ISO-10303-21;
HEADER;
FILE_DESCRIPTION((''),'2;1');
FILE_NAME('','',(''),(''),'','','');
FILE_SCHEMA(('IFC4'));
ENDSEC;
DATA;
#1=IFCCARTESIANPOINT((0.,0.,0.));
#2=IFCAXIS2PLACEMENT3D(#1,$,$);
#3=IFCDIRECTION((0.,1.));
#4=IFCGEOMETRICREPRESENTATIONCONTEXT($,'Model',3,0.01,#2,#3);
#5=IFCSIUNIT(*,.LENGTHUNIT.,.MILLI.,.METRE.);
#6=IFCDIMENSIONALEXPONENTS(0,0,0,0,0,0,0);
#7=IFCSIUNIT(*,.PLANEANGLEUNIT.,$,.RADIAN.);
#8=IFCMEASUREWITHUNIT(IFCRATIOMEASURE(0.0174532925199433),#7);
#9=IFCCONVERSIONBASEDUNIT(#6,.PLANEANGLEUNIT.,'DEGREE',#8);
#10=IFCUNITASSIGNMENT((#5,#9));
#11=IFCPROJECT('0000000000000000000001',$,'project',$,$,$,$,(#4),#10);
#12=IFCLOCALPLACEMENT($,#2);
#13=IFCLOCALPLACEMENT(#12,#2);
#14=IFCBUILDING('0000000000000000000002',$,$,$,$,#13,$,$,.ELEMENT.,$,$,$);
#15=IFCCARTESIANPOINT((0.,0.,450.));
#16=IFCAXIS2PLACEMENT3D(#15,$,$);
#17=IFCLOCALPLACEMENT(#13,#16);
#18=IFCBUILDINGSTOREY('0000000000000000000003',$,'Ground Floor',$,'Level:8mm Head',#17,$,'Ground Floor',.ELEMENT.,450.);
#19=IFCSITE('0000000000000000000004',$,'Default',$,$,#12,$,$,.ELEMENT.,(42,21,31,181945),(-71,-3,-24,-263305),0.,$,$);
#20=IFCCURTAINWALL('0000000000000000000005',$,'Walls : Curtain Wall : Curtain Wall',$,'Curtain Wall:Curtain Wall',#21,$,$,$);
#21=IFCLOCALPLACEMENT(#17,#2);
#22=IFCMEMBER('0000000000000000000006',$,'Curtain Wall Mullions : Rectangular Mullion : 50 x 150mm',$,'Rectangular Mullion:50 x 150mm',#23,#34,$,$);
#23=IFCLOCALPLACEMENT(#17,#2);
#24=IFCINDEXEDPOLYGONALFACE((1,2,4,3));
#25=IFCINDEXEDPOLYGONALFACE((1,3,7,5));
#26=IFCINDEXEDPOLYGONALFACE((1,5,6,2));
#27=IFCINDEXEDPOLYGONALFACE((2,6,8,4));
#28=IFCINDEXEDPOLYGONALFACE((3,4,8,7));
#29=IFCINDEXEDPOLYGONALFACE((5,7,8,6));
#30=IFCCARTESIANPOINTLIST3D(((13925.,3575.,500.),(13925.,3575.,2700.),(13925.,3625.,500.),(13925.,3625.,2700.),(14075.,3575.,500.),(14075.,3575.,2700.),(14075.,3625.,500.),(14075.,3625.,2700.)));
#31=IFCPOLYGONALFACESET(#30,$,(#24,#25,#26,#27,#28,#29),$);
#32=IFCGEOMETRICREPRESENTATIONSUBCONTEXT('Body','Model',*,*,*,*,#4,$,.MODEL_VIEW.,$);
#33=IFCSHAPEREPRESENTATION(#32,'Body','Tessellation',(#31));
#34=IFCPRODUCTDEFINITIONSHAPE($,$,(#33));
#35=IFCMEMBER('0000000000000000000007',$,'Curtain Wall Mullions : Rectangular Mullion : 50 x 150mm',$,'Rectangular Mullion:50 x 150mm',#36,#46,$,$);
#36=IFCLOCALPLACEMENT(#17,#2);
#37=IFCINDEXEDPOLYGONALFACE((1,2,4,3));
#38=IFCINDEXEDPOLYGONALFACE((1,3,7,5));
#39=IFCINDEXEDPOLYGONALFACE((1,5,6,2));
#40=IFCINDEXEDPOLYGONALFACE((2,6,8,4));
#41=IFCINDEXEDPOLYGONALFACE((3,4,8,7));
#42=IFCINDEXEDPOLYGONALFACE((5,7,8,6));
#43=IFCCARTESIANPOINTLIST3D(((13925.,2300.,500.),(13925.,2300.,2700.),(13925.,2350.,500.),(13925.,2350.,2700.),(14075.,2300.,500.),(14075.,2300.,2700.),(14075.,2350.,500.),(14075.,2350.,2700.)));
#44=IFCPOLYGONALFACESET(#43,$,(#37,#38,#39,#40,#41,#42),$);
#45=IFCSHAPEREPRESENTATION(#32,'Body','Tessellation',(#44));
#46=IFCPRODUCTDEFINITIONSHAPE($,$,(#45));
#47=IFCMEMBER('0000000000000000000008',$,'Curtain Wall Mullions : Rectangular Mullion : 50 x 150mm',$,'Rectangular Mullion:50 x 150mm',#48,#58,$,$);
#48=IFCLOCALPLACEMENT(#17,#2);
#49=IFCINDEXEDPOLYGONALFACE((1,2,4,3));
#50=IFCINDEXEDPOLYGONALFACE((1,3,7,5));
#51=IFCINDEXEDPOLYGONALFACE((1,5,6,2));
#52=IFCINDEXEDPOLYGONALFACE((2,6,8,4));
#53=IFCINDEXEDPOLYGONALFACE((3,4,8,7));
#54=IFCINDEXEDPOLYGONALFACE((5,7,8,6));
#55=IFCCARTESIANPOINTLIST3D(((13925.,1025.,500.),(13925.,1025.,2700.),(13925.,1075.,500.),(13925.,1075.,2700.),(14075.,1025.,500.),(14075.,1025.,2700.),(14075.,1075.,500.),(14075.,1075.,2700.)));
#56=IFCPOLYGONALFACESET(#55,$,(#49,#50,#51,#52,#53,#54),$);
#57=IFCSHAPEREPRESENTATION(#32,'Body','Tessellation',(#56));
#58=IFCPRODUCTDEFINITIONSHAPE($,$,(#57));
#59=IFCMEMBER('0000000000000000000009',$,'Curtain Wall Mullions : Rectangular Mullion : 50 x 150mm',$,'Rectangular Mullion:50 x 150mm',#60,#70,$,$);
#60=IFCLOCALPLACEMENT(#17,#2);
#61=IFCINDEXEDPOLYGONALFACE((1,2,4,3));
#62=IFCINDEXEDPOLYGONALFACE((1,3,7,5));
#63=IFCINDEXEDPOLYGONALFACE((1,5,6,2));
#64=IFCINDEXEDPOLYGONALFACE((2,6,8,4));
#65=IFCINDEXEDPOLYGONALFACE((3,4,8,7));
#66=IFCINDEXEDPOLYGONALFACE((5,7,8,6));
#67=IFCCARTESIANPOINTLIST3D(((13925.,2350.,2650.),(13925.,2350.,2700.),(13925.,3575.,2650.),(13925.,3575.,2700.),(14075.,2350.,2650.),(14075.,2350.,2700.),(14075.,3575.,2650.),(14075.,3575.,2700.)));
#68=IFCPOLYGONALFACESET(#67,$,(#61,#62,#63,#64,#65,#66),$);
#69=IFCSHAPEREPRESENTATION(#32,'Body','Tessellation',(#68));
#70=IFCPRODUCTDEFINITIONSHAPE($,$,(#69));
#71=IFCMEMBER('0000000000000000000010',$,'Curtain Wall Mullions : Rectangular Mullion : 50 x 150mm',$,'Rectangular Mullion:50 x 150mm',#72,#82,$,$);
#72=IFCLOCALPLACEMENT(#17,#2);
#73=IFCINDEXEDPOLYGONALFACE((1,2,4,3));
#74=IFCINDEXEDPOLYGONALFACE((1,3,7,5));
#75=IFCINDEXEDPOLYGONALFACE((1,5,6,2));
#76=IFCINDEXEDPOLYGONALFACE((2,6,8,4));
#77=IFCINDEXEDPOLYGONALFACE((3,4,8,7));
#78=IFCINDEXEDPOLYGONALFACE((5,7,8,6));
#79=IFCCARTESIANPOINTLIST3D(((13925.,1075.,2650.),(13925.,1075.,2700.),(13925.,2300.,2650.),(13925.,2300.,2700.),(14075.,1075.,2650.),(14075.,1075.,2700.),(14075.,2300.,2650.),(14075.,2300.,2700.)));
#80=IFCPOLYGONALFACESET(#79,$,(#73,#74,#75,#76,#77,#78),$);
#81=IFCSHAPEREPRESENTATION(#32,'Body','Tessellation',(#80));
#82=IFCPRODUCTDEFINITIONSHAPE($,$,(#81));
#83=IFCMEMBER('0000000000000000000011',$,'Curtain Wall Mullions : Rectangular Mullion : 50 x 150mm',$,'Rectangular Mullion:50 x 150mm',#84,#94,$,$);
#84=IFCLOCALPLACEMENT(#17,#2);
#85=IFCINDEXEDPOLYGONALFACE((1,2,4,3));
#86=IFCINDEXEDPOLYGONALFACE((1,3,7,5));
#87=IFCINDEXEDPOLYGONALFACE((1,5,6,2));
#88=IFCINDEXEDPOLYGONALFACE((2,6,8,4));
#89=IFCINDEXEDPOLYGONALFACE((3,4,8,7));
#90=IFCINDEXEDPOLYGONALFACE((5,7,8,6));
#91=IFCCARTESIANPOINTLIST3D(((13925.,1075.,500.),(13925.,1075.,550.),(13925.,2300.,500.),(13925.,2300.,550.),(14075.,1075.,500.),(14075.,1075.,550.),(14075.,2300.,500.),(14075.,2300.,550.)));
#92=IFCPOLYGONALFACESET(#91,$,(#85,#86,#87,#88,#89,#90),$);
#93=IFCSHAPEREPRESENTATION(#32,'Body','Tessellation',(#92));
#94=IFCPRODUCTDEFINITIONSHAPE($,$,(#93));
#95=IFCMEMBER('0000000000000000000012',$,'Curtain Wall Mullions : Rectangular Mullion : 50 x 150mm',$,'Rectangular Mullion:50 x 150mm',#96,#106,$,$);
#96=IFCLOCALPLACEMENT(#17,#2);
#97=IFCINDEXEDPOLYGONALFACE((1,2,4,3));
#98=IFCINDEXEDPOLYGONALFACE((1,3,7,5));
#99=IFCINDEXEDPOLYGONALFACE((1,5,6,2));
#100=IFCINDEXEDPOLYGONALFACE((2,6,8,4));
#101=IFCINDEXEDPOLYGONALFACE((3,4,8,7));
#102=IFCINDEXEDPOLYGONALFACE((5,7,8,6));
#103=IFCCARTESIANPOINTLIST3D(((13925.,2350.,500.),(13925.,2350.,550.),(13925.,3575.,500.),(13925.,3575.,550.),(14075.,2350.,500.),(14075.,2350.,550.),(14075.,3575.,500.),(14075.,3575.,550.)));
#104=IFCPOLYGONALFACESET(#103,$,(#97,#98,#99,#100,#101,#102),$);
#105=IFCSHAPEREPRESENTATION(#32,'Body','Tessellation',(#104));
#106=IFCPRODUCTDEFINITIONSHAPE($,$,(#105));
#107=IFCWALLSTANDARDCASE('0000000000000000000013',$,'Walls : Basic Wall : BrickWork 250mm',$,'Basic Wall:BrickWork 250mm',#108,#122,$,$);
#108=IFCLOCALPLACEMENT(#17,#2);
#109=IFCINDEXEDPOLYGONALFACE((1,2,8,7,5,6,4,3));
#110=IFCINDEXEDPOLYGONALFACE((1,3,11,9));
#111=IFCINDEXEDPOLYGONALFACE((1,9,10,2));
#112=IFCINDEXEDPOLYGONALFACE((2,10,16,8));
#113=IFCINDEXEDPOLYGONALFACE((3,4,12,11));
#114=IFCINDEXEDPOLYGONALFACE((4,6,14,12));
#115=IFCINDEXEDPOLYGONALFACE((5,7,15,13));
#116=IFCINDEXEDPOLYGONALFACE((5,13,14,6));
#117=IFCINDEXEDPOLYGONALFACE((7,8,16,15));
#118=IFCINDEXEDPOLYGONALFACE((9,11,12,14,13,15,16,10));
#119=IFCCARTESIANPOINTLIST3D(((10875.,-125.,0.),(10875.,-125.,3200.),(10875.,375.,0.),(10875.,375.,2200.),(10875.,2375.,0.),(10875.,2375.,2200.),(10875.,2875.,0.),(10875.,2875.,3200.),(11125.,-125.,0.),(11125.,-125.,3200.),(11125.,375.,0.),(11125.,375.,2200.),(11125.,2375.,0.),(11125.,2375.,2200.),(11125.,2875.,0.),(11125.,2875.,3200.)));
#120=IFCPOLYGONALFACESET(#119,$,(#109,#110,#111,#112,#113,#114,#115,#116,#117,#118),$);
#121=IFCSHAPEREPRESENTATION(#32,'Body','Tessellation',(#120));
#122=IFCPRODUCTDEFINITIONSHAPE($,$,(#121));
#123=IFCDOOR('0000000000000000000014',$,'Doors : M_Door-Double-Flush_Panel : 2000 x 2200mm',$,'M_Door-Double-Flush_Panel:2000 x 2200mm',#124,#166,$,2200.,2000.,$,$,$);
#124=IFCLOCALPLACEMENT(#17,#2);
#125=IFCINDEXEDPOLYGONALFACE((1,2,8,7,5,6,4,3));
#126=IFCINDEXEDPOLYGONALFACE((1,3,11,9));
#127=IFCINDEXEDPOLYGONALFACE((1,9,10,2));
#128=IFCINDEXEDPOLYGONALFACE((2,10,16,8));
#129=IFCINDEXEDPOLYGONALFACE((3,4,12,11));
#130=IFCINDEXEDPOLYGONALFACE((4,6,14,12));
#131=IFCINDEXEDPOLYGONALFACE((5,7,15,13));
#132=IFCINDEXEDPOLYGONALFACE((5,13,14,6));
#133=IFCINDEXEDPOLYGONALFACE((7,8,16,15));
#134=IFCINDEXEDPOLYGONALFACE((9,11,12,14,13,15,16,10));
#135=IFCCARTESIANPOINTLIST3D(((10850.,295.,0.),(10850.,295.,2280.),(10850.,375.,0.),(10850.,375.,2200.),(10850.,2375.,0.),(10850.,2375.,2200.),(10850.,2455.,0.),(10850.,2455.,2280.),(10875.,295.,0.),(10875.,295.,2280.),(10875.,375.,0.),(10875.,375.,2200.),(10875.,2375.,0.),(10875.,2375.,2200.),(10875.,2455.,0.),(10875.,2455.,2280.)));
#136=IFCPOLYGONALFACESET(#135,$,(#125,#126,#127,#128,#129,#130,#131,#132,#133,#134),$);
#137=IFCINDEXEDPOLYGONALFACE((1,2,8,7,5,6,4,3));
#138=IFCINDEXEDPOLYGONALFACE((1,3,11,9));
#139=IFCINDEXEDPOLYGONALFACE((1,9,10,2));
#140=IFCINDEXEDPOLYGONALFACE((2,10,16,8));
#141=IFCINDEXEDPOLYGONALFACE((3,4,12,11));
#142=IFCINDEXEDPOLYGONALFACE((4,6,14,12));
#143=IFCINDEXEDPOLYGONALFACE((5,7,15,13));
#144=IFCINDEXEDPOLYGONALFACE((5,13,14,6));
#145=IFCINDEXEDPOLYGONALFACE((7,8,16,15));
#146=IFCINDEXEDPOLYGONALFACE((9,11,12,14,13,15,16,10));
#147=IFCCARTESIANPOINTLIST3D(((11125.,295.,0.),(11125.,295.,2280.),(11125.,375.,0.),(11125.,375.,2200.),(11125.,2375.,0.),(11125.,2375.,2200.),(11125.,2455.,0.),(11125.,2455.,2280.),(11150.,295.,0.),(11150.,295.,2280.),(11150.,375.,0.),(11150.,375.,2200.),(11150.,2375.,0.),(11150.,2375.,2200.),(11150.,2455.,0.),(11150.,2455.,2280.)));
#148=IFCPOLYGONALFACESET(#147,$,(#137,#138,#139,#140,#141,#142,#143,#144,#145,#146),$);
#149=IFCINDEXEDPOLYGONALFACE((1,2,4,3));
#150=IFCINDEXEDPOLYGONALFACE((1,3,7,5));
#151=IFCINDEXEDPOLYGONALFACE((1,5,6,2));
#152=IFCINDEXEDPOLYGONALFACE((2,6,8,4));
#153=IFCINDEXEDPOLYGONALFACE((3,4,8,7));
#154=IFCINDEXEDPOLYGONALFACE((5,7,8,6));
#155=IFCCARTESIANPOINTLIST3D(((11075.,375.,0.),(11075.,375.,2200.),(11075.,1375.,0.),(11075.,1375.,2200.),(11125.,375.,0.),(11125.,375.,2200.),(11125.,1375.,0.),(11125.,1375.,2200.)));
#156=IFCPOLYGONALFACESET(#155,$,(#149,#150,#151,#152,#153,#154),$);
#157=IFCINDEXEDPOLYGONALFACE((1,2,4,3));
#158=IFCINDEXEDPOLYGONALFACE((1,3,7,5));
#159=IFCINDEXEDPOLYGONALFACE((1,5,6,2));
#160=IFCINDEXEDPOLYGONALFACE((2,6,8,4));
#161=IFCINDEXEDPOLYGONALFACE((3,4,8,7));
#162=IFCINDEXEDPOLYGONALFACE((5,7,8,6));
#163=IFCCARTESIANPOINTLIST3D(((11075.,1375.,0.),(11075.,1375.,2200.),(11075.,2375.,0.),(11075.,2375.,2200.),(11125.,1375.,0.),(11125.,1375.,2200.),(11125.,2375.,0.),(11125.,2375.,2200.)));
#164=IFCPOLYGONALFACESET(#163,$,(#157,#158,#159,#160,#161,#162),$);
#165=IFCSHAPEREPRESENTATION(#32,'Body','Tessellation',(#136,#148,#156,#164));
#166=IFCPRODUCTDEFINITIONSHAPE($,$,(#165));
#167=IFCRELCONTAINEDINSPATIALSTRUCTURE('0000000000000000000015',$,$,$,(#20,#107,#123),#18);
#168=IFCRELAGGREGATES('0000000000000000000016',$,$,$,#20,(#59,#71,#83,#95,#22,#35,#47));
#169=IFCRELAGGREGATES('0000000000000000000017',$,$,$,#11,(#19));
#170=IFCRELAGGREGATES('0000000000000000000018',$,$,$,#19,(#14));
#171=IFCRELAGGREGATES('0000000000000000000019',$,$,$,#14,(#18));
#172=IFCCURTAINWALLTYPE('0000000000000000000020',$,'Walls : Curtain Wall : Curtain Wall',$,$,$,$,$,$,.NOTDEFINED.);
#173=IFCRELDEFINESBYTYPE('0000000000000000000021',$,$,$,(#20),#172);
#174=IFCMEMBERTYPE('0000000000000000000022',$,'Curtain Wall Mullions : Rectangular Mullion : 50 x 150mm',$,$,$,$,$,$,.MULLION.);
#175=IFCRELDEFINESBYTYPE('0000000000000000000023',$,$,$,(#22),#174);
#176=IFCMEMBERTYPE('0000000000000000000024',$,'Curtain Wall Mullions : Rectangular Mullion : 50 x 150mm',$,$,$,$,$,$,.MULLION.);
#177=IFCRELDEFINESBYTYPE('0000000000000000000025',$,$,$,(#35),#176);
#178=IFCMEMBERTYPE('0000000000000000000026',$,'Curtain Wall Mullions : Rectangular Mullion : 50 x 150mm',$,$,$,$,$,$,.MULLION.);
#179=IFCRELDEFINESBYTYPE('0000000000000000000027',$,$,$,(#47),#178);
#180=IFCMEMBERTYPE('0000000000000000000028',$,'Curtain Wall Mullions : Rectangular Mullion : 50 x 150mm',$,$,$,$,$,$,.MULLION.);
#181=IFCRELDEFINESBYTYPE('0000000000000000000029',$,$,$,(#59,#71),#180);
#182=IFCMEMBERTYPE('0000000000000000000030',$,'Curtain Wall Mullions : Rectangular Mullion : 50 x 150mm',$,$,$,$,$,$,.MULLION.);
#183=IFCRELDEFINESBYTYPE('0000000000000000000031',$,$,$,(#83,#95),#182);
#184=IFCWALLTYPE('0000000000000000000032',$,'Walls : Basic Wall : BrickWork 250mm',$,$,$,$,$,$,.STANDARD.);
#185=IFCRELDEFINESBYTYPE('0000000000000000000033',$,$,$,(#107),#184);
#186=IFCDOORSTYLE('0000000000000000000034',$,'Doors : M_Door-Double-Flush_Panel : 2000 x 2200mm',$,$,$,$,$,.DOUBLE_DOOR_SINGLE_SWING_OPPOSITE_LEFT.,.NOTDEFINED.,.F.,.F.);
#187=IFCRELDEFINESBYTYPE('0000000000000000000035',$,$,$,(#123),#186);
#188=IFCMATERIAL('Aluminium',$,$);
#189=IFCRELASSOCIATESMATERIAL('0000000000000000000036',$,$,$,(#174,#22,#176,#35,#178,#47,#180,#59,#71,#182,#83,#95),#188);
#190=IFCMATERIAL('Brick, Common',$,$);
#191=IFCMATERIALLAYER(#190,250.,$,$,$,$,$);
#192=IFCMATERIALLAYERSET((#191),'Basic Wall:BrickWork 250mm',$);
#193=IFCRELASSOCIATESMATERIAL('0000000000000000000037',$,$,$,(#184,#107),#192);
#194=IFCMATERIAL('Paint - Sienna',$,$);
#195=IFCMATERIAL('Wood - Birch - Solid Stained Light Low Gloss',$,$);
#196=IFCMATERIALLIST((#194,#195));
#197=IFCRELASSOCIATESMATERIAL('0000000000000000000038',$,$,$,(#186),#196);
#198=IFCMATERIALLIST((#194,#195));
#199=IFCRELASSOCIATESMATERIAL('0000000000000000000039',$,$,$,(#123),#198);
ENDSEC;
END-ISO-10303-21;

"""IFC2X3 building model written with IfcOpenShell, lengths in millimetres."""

from ifc_helpers import new_model, entity, si_unit, converted_unit, direction, frame, frame_2d, origin, origin_2d_with_axis, place, context, subcontext, project, spatial, polyline, rectangle, outline, extrude, clip, halfspace, source, transform, mapped, material, material_list, layer, layer_set, layer_usage, type_object, type_shapes, element, fill, aggregate, save


model = new_model("IFC2X3")

# Units and contexts
model_context = context("Model", 3, precision=0.01, world=origin(), true_north=direction((0.0, 1.0)))
body_context = subcontext(model_context, "Body", "Model", "MODEL_VIEW")
ifc_project = project(units=[si_unit("LENGTHUNIT", "METRE", prefix="MILLI"), converted_unit("PLANEANGLEUNIT", "DEGREE", entity("IfcRatioMeasure", 0.0174532925199433), si_unit("PLANEANGLEUNIT", "RADIAN"), dimensions=[0, 0, 0, 0, 0, 0, 0])], contexts=[model_context])

# Site, building, storey
site_placement = place(None, origin())
site = spatial("IfcSite", under=ifc_project, at=site_placement, Name="Default", CompositionType="ELEMENT", RefLatitude=(42, 21, 31, 181945), RefLongitude=(-71, -3, -24, -263305), RefElevation=0.0)
building_placement = place(site_placement, origin())
building = spatial("IfcBuilding", under=site, at=building_placement, CompositionType="ELEMENT")
storey_placement = place(building_placement, frame((0.0, 0.0, 450.0)))
storey = spatial("IfcBuildingStorey", under=building, at=storey_placement, Name="Ground Floor", ObjectType="Level:8mm Head", LongName="Ground Floor", CompositionType="ELEMENT", Elevation=450.0)

# Curtain wall, members
curtain_wall_type = type_object("IfcCurtainWallType", Name="Walls : Curtain Wall : Curtain Wall", PredefinedType="NOTDEFINED")
curtain_wall_placement = place(storey_placement, frame((0.0, 0.0, -450.0)))
curtain_wall = element("IfcCurtainWall", 1, at=curtain_wall_placement, inside=storey, type_object=curtain_wall_type, Name="Walls : Curtain Wall : Curtain Wall", ObjectType="Curtain Wall:Curtain Wall")
ifc_material_1 = material(Name="Aluminium")
member_type_1 = type_object("IfcMemberType", Name="Curtain Wall Mullions : Rectangular Mullion : 50 x 150mm", PredefinedType="MULLION", material=ifc_material_1)
shared_shape_1 = source(origin(), body_context, "Body", "SweptSolid", [
    extrude(rectangle(XDim=150.0, YDim=50.0, at=origin_2d_with_axis()), frame((-25.0, 0.0, -2200.0), z_axis=(0.0, 0.0, 1.0), x_axis=(0.0, -1.0, 0.0)), (0.0, 0.0, 1.0), 2200.0),
])
type_shapes(member_type_1, [shared_shape_1])
member_1_placement = place(storey_placement, frame((14000.0, 3625.0, 500.0), z_axis=(0.0, 0.0, -1.0), x_axis=(0.0, 1.0, 0.0)))
member_1 = element("IfcMember", 2, at=member_1_placement, type_object=member_type_1, material=ifc_material_1, Name="Curtain Wall Mullions : Rectangular Mullion : 50 x 150mm", ObjectType="Rectangular Mullion:50 x 150mm", context=body_context, shape_type="MappedRepresentation", body=[
    mapped(shared_shape_1, transform((0.0, 0.0, 0.0), scale=1.0)),
])
member_type_2 = type_object("IfcMemberType", Name="Curtain Wall Mullions : Rectangular Mullion : 50 x 150mm", PredefinedType="MULLION", material=ifc_material_1)
shared_shape_2 = source(origin(), body_context, "Body", "SweptSolid", [
    extrude(rectangle(XDim=150.0, YDim=50.0, at=origin_2d_with_axis()), frame((0.0, 0.0, -2200.0), z_axis=(0.0, 0.0, 1.0), x_axis=(0.0, -1.0, 0.0)), (0.0, 0.0, 1.0), 2200.0),
])
type_shapes(member_type_2, [shared_shape_2])
member_2_placement = place(storey_placement, frame((14000.0, 2325.0, 500.0), z_axis=(0.0, 0.0, -1.0), x_axis=(0.0, 1.0, 0.0)))
member_2 = element("IfcMember", 3, at=member_2_placement, type_object=member_type_2, material=ifc_material_1, Name="Curtain Wall Mullions : Rectangular Mullion : 50 x 150mm", ObjectType="Rectangular Mullion:50 x 150mm", context=body_context, shape_type="MappedRepresentation", body=[
    mapped(shared_shape_2, transform((0.0, 0.0, 0.0), scale=1.0)),
])
member_type_3 = type_object("IfcMemberType", Name="Curtain Wall Mullions : Rectangular Mullion : 50 x 150mm", PredefinedType="MULLION", material=ifc_material_1)
shared_shape_3 = source(origin(), body_context, "Body", "SweptSolid", [
    extrude(rectangle(XDim=150.0, YDim=50.0, at=origin_2d_with_axis()), frame((-25.0, 0.0, -2200.0), z_axis=(0.0, 0.0, 1.0), x_axis=(0.0, -1.0, 0.0)), (0.0, 0.0, 1.0), 2200.0),
])
type_shapes(member_type_3, [shared_shape_3])
member_3_placement = place(storey_placement, frame((14000.0, 1025.0, 2700.0), z_axis=(0.0, 0.0, 1.0), x_axis=(0.0, -1.0, 0.0)))
member_3 = element("IfcMember", 4, at=member_3_placement, type_object=member_type_3, material=ifc_material_1, Name="Curtain Wall Mullions : Rectangular Mullion : 50 x 150mm", ObjectType="Rectangular Mullion:50 x 150mm", context=body_context, shape_type="MappedRepresentation", body=[
    mapped(shared_shape_3, transform((0.0, 0.0, 0.0), scale=1.0)),
])
member_type_4 = type_object("IfcMemberType", Name="Curtain Wall Mullions : Rectangular Mullion : 50 x 150mm", PredefinedType="MULLION", material=ifc_material_1)
shared_shape_4 = source(origin(), body_context, "Body", "SweptSolid", [
    extrude(rectangle(XDim=150.0, YDim=50.0, at=origin_2d_with_axis()), frame((-25.0, 0.0, -1225.0), z_axis=(0.0, 0.0, 1.0), x_axis=(0.0, -1.0, 0.0)), (0.0, 0.0, 1.0), 1225.0),
])
type_shapes(member_type_4, [shared_shape_4])
member_4_placement = place(storey_placement, frame((14000.0, 3575.0, 2700.0), z_axis=(0.0, 1.0, 0.0), x_axis=(0.0, 0.0, 1.0)))
member_4 = element("IfcMember", 5, at=member_4_placement, type_object=member_type_4, material=ifc_material_1, Name="Curtain Wall Mullions : Rectangular Mullion : 50 x 150mm", ObjectType="Rectangular Mullion:50 x 150mm", context=body_context, shape_type="MappedRepresentation", body=[
    mapped(shared_shape_4, transform((0.0, 0.0, 0.0), scale=1.0)),
])
member_5_placement = place(storey_placement, frame((14000.0, 2300.0, 2700.0), z_axis=(0.0, 1.0, 0.0), x_axis=(0.0, 0.0, 1.0)))
member_5 = element("IfcMember", 6, at=member_5_placement, type_object=member_type_4, material=ifc_material_1, Name="Curtain Wall Mullions : Rectangular Mullion : 50 x 150mm", ObjectType="Rectangular Mullion:50 x 150mm", context=body_context, shape_type="MappedRepresentation", body=[
    mapped(shared_shape_4, transform((0.0, 0.0, 0.0), scale=1.0)),
])
member_type_5 = type_object("IfcMemberType", Name="Curtain Wall Mullions : Rectangular Mullion : 50 x 150mm", PredefinedType="MULLION", material=ifc_material_1)
shared_shape_5 = source(origin(), body_context, "Body", "SweptSolid", [
    extrude(rectangle(XDim=150.0, YDim=50.0, at=origin_2d_with_axis()), frame((-25.0, 0.0, -1225.0), z_axis=(0.0, 0.0, 1.0), x_axis=(0.0, -1.0, 0.0)), (0.0, 0.0, 1.0), 1225.0),
])
type_shapes(member_type_5, [shared_shape_5])
member_6_placement = place(storey_placement, frame((14000.0, 1075.0, 500.0), z_axis=(0.0, -1.0, 0.0), x_axis=(0.0, 0.0, -1.0)))
member_6 = element("IfcMember", 7, at=member_6_placement, type_object=member_type_5, material=ifc_material_1, Name="Curtain Wall Mullions : Rectangular Mullion : 50 x 150mm", ObjectType="Rectangular Mullion:50 x 150mm", context=body_context, shape_type="MappedRepresentation", body=[
    mapped(shared_shape_5, transform((0.0, 0.0, 0.0), scale=1.0)),
])
member_7_placement = place(storey_placement, frame((14000.0, 2350.0, 500.0), z_axis=(0.0, -1.0, 0.0), x_axis=(0.0, 0.0, -1.0)))
member_7 = element("IfcMember", 8, at=member_7_placement, type_object=member_type_5, material=ifc_material_1, Name="Curtain Wall Mullions : Rectangular Mullion : 50 x 150mm", ObjectType="Rectangular Mullion:50 x 150mm", context=body_context, shape_type="MappedRepresentation", body=[
    mapped(shared_shape_5, transform((0.0, 0.0, 0.0), scale=1.0)),
])
aggregate(curtain_wall, [member_4, member_5, member_6, member_7, member_1, member_2, member_3])

# Wall, opening, door
ifc_material_2 = material(Name="Brick, Common")
ifc_layer = layer(ifc_material_2, 250.0)
ifc_layer_set = layer_set([ifc_layer], Name="Basic Wall:BrickWork 250mm")
ifc_layer_usage_1 = layer_usage(ifc_layer_set, "AXIS2", "POSITIVE", -125.0)
wall_type = type_object("IfcWallType", Name="Walls : Basic Wall : BrickWork 250mm", PredefinedType="STANDARD", material=ifc_layer_set)
wall_1_placement = place(storey_placement, frame((11000.0, 2875.0, 0.0), z_axis=(0.0, 0.0, 1.0), x_axis=(0.0, -1.0, 0.0)))
wall_1 = element("IfcWallStandardCase", 9, at=wall_1_placement, inside=storey, type_object=wall_type, material=ifc_layer_usage_1, Name="Walls : Basic Wall : BrickWork 250mm", ObjectType="Basic Wall:BrickWork 250mm", context=body_context, shape_type="Clipping", body=[
    clip(extrude(rectangle(XDim=3000.0, YDim=250.0, at=frame_2d((1500.0, 0.0), x_axis=(-1.0, 0.0))), origin(), (0.0, 0.0, 1.0), 3200.0), halfspace(origin(), True)),
])
opening_1_placement = place(wall_1_placement, frame((500.0, -125.0, 0.0)))
opening_1 = element("IfcOpeningElement", 10, at=opening_1_placement, cuts=wall_1, ObjectType="Opening", context=body_context, shape_type="SweptSolid", body=[
    extrude(rectangle(XDim=2200.0, YDim=2000.0, at=frame_2d((1100.0, 1000.0), x_axis=(1.0, 0.0))), frame((0.0, 0.0, 0.0), z_axis=(0.0, 1.0, 0.0), x_axis=(0.0, 0.0, 1.0)), (0.0, 0.0, 1.0), 250.0),
])
ifc_material_3 = material(Name="Paint - Sienna")
ifc_material_4 = material(Name="Wood - Birch - Solid Stained Light Low Gloss")
ifc_material_list_1 = material_list([ifc_material_3, ifc_material_4])
ifc_material_list_2 = material_list([ifc_material_3, ifc_material_4])
door_style = type_object("IfcDoorStyle", Name="Doors : M_Door-Double-Flush_Panel : 2000 x 2200mm", ConstructionType="NOTDEFINED", OperationType="DOUBLE_DOOR_SINGLE_SWING_OPPOSITE_LEFT", ParameterTakesPrecedence=False, Sizeable=False, material=ifc_material_list_2)
shared_shape_6 = source(origin(), body_context, "Body", "SweptSolid", [
    extrude(outline(polyline([(-1080.0, 1000.0), (1120.0, 1000.0), (1120.0, 1080.0), (-1160.0, 1080.0), (-1160.0, -1080.0), (1120.0, -1080.0), (1120.0, -1000.0), (-1080.0, -1000.0), (-1080.0, 1000.0)])), frame((1000.0, -25.0, 1120.0), z_axis=(0.0, 1.0, 0.0), x_axis=(0.0, 0.0, -1.0)), (0.0, 0.0, 1.0), 25.0),
    extrude(outline(polyline([(-1080.0, 1000.0), (1120.0, 1000.0), (1120.0, 1080.0), (-1160.0, 1080.0), (-1160.0, -1080.0), (1120.0, -1080.0), (1120.0, -1000.0), (-1080.0, -1000.0), (-1080.0, 1000.0)])), frame((1000.0, 250.0, 1120.0), z_axis=(0.0, 1.0, 0.0), x_axis=(0.0, 0.0, -1.0)), (0.0, 0.0, 1.0), 25.0),
    extrude(rectangle(XDim=50.0, YDim=1000.0, at=frame_2d((0.0, 0.0), x_axis=(1.0, 0.0))), frame((1500.0, 225.0, 0.0), z_axis=(0.0, 0.0, 1.0), x_axis=(0.0, -1.0, 0.0)), (0.0, 0.0, 1.0), 2200.0),
    extrude(rectangle(XDim=50.0, YDim=1000.0, at=frame_2d((0.0, 0.0), x_axis=(1.0, 0.0))), frame((500.0, 225.0, 0.0), z_axis=(0.0, 0.0, 1.0), x_axis=(0.0, -1.0, 0.0)), (0.0, 0.0, 1.0), 2200.0),
])
type_shapes(door_style, [shared_shape_6])
door_placement = place(opening_1_placement, origin())
door = element("IfcDoor", 11, at=door_placement, inside=storey, type_object=door_style, material=ifc_material_list_1, Name="Doors : M_Door-Double-Flush_Panel : 2000 x 2200mm", ObjectType="M_Door-Double-Flush_Panel:2000 x 2200mm", OverallHeight=2200.0, OverallWidth=2000.0, context=body_context, shape_type="MappedRepresentation", body=[
    mapped(shared_shape_6, transform((0.0, 0.0, 0.0), scale=1.0)),
])
fill(opening_1, door)

save(model, "model.ifc")
